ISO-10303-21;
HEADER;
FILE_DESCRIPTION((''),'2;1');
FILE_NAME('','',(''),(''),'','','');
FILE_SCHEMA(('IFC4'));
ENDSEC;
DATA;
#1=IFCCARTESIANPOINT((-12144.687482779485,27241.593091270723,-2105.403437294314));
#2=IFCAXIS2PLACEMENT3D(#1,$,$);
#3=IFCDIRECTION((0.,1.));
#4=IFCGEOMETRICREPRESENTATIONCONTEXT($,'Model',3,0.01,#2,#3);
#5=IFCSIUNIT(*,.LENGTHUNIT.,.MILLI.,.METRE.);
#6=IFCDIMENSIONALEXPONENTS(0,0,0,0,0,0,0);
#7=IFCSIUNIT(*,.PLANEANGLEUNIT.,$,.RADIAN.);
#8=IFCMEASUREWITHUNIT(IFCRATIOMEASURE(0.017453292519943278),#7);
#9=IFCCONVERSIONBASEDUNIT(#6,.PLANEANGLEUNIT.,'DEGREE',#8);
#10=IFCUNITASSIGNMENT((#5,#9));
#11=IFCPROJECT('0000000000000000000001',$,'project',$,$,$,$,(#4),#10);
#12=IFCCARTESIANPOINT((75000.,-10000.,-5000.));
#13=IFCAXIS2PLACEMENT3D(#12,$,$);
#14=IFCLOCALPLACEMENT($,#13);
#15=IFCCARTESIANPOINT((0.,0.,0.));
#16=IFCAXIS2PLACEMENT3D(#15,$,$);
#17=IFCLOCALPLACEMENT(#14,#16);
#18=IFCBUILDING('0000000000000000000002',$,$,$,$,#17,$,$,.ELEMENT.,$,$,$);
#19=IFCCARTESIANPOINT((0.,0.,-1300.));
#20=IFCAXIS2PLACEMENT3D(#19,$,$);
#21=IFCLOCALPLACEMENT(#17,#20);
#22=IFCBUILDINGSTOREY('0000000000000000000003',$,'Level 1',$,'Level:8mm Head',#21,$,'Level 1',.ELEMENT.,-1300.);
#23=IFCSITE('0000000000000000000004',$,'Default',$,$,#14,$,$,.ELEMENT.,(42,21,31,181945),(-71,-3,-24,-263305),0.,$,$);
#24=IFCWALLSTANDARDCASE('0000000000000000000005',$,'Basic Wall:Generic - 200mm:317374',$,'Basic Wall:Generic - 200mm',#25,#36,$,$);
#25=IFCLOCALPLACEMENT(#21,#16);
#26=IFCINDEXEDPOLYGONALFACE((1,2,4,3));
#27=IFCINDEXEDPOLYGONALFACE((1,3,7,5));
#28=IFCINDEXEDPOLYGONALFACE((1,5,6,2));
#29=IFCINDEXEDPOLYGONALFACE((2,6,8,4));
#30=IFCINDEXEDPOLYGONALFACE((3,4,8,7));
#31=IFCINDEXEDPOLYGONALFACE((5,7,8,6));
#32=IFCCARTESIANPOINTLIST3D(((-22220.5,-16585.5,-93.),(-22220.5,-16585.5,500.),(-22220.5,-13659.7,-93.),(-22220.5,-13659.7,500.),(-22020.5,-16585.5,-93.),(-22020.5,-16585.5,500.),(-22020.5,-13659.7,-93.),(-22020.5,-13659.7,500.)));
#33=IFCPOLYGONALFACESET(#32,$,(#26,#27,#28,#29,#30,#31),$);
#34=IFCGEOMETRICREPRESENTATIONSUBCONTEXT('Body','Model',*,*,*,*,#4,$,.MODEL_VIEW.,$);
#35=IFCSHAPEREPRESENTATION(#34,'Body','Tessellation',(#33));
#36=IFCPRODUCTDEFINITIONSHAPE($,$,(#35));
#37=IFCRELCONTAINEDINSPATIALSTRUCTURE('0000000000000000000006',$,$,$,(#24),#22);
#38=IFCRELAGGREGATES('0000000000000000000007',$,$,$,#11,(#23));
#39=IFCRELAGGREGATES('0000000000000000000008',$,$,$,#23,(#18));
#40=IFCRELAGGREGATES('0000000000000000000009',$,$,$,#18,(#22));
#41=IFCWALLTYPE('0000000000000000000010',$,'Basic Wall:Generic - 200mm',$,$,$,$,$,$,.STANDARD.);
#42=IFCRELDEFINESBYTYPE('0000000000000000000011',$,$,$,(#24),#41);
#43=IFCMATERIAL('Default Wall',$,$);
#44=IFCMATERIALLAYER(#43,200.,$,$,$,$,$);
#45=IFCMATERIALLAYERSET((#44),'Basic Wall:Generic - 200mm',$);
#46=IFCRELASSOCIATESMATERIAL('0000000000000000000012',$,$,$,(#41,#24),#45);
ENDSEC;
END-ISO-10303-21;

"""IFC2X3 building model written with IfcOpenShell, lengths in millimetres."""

from ifc_helpers import new_model, entity, si_unit, converted_unit, direction, frame, frame_2d, origin, place, context, subcontext, project, spatial, polyline, rectangle, extrude, clip, bounded_halfspace, material, layer, layer_set, layer_usage, type_object, element, save


model = new_model("IFC2X3")

# Units and contexts
model_context = context("Model", 3, precision=0.01, world=frame((-12144.687482779485, 27241.593091270723, -2105.403437294314)), true_north=direction((0.0, 1.0)))
body_context = subcontext(model_context, "Body", "Model", "MODEL_VIEW")
ifc_project = project(units=[si_unit("LENGTHUNIT", "METRE", prefix="MILLI"), converted_unit("PLANEANGLEUNIT", "DEGREE", entity("IfcRatioMeasure", 0.017453292519943278), si_unit("PLANEANGLEUNIT", "RADIAN"), dimensions=[0, 0, 0, 0, 0, 0, 0])], contexts=[model_context])

# Site, building, storey
site_placement = place(None, frame((75000.0, -10000.0, -5000.0)))
site = spatial("IfcSite", under=ifc_project, at=site_placement, Name="Default", CompositionType="ELEMENT", RefLatitude=(42, 21, 31, 181945), RefLongitude=(-71, -3, -24, -263305), RefElevation=0.0)
building_placement = place(site_placement, origin())
building = spatial("IfcBuilding", under=site, at=building_placement, CompositionType="ELEMENT")
storey_placement = place(building_placement, frame((0.0, 0.0, -1300.0)))
storey = spatial("IfcBuildingStorey", under=building, at=storey_placement, Name="Level 1", ObjectType="Level:8mm Head", LongName="Level 1", CompositionType="ELEMENT", Elevation=-1300.0)

# Wall
ifc_material = material(Name="Default Wall")
ifc_layer = layer(ifc_material, 200.0)
ifc_layer_set = layer_set([ifc_layer], Name="Basic Wall:Generic - 200mm")
wall_type = type_object("IfcWallType", Name="Basic Wall:Generic - 200mm", PredefinedType="STANDARD", material=ifc_layer_set)
ifc_layer_usage_1 = layer_usage(ifc_layer_set, "AXIS2", "NEGATIVE", 100.0)
wall_1_placement = place(storey_placement, frame((-22120.5, -13659.7, -93.0), z_axis=(0.0, 0.0, 1.0), x_axis=(0.0, -1.0, 0.0)))
element("IfcWallStandardCase", 1, at=wall_1_placement, inside=storey, type_object=wall_type, material=ifc_layer_usage_1, Name="Basic Wall:Generic - 200mm:317374", ObjectType="Basic Wall:Generic - 200mm", context=body_context, shape_type="Clipping", body=[
    clip(extrude(rectangle(XDim=2925.8, YDim=200.0, at=frame_2d((1462.9, 0.0), x_axis=(-1.0, 0.0))), origin(), (0.0, 0.0, 1.0), 593.0), bounded_halfspace(frame((2925.8, -100.0, 0.0), z_axis=(0.0, 0.0, 1.0), x_axis=(0.0, -1.0, 0.0)), True, frame((2925.8, -100.0, 0.0), z_axis=(0.0, 0.0, 1.0), x_axis=(0.0, -1.0, 0.0)), polyline([(0.0, 0.0), (-60960.0, 0.0), (-60960.0, -891789.6), (0.0, -891789.6), (0.0, 0.0)]))),
])

save(model, "model.ifc")
